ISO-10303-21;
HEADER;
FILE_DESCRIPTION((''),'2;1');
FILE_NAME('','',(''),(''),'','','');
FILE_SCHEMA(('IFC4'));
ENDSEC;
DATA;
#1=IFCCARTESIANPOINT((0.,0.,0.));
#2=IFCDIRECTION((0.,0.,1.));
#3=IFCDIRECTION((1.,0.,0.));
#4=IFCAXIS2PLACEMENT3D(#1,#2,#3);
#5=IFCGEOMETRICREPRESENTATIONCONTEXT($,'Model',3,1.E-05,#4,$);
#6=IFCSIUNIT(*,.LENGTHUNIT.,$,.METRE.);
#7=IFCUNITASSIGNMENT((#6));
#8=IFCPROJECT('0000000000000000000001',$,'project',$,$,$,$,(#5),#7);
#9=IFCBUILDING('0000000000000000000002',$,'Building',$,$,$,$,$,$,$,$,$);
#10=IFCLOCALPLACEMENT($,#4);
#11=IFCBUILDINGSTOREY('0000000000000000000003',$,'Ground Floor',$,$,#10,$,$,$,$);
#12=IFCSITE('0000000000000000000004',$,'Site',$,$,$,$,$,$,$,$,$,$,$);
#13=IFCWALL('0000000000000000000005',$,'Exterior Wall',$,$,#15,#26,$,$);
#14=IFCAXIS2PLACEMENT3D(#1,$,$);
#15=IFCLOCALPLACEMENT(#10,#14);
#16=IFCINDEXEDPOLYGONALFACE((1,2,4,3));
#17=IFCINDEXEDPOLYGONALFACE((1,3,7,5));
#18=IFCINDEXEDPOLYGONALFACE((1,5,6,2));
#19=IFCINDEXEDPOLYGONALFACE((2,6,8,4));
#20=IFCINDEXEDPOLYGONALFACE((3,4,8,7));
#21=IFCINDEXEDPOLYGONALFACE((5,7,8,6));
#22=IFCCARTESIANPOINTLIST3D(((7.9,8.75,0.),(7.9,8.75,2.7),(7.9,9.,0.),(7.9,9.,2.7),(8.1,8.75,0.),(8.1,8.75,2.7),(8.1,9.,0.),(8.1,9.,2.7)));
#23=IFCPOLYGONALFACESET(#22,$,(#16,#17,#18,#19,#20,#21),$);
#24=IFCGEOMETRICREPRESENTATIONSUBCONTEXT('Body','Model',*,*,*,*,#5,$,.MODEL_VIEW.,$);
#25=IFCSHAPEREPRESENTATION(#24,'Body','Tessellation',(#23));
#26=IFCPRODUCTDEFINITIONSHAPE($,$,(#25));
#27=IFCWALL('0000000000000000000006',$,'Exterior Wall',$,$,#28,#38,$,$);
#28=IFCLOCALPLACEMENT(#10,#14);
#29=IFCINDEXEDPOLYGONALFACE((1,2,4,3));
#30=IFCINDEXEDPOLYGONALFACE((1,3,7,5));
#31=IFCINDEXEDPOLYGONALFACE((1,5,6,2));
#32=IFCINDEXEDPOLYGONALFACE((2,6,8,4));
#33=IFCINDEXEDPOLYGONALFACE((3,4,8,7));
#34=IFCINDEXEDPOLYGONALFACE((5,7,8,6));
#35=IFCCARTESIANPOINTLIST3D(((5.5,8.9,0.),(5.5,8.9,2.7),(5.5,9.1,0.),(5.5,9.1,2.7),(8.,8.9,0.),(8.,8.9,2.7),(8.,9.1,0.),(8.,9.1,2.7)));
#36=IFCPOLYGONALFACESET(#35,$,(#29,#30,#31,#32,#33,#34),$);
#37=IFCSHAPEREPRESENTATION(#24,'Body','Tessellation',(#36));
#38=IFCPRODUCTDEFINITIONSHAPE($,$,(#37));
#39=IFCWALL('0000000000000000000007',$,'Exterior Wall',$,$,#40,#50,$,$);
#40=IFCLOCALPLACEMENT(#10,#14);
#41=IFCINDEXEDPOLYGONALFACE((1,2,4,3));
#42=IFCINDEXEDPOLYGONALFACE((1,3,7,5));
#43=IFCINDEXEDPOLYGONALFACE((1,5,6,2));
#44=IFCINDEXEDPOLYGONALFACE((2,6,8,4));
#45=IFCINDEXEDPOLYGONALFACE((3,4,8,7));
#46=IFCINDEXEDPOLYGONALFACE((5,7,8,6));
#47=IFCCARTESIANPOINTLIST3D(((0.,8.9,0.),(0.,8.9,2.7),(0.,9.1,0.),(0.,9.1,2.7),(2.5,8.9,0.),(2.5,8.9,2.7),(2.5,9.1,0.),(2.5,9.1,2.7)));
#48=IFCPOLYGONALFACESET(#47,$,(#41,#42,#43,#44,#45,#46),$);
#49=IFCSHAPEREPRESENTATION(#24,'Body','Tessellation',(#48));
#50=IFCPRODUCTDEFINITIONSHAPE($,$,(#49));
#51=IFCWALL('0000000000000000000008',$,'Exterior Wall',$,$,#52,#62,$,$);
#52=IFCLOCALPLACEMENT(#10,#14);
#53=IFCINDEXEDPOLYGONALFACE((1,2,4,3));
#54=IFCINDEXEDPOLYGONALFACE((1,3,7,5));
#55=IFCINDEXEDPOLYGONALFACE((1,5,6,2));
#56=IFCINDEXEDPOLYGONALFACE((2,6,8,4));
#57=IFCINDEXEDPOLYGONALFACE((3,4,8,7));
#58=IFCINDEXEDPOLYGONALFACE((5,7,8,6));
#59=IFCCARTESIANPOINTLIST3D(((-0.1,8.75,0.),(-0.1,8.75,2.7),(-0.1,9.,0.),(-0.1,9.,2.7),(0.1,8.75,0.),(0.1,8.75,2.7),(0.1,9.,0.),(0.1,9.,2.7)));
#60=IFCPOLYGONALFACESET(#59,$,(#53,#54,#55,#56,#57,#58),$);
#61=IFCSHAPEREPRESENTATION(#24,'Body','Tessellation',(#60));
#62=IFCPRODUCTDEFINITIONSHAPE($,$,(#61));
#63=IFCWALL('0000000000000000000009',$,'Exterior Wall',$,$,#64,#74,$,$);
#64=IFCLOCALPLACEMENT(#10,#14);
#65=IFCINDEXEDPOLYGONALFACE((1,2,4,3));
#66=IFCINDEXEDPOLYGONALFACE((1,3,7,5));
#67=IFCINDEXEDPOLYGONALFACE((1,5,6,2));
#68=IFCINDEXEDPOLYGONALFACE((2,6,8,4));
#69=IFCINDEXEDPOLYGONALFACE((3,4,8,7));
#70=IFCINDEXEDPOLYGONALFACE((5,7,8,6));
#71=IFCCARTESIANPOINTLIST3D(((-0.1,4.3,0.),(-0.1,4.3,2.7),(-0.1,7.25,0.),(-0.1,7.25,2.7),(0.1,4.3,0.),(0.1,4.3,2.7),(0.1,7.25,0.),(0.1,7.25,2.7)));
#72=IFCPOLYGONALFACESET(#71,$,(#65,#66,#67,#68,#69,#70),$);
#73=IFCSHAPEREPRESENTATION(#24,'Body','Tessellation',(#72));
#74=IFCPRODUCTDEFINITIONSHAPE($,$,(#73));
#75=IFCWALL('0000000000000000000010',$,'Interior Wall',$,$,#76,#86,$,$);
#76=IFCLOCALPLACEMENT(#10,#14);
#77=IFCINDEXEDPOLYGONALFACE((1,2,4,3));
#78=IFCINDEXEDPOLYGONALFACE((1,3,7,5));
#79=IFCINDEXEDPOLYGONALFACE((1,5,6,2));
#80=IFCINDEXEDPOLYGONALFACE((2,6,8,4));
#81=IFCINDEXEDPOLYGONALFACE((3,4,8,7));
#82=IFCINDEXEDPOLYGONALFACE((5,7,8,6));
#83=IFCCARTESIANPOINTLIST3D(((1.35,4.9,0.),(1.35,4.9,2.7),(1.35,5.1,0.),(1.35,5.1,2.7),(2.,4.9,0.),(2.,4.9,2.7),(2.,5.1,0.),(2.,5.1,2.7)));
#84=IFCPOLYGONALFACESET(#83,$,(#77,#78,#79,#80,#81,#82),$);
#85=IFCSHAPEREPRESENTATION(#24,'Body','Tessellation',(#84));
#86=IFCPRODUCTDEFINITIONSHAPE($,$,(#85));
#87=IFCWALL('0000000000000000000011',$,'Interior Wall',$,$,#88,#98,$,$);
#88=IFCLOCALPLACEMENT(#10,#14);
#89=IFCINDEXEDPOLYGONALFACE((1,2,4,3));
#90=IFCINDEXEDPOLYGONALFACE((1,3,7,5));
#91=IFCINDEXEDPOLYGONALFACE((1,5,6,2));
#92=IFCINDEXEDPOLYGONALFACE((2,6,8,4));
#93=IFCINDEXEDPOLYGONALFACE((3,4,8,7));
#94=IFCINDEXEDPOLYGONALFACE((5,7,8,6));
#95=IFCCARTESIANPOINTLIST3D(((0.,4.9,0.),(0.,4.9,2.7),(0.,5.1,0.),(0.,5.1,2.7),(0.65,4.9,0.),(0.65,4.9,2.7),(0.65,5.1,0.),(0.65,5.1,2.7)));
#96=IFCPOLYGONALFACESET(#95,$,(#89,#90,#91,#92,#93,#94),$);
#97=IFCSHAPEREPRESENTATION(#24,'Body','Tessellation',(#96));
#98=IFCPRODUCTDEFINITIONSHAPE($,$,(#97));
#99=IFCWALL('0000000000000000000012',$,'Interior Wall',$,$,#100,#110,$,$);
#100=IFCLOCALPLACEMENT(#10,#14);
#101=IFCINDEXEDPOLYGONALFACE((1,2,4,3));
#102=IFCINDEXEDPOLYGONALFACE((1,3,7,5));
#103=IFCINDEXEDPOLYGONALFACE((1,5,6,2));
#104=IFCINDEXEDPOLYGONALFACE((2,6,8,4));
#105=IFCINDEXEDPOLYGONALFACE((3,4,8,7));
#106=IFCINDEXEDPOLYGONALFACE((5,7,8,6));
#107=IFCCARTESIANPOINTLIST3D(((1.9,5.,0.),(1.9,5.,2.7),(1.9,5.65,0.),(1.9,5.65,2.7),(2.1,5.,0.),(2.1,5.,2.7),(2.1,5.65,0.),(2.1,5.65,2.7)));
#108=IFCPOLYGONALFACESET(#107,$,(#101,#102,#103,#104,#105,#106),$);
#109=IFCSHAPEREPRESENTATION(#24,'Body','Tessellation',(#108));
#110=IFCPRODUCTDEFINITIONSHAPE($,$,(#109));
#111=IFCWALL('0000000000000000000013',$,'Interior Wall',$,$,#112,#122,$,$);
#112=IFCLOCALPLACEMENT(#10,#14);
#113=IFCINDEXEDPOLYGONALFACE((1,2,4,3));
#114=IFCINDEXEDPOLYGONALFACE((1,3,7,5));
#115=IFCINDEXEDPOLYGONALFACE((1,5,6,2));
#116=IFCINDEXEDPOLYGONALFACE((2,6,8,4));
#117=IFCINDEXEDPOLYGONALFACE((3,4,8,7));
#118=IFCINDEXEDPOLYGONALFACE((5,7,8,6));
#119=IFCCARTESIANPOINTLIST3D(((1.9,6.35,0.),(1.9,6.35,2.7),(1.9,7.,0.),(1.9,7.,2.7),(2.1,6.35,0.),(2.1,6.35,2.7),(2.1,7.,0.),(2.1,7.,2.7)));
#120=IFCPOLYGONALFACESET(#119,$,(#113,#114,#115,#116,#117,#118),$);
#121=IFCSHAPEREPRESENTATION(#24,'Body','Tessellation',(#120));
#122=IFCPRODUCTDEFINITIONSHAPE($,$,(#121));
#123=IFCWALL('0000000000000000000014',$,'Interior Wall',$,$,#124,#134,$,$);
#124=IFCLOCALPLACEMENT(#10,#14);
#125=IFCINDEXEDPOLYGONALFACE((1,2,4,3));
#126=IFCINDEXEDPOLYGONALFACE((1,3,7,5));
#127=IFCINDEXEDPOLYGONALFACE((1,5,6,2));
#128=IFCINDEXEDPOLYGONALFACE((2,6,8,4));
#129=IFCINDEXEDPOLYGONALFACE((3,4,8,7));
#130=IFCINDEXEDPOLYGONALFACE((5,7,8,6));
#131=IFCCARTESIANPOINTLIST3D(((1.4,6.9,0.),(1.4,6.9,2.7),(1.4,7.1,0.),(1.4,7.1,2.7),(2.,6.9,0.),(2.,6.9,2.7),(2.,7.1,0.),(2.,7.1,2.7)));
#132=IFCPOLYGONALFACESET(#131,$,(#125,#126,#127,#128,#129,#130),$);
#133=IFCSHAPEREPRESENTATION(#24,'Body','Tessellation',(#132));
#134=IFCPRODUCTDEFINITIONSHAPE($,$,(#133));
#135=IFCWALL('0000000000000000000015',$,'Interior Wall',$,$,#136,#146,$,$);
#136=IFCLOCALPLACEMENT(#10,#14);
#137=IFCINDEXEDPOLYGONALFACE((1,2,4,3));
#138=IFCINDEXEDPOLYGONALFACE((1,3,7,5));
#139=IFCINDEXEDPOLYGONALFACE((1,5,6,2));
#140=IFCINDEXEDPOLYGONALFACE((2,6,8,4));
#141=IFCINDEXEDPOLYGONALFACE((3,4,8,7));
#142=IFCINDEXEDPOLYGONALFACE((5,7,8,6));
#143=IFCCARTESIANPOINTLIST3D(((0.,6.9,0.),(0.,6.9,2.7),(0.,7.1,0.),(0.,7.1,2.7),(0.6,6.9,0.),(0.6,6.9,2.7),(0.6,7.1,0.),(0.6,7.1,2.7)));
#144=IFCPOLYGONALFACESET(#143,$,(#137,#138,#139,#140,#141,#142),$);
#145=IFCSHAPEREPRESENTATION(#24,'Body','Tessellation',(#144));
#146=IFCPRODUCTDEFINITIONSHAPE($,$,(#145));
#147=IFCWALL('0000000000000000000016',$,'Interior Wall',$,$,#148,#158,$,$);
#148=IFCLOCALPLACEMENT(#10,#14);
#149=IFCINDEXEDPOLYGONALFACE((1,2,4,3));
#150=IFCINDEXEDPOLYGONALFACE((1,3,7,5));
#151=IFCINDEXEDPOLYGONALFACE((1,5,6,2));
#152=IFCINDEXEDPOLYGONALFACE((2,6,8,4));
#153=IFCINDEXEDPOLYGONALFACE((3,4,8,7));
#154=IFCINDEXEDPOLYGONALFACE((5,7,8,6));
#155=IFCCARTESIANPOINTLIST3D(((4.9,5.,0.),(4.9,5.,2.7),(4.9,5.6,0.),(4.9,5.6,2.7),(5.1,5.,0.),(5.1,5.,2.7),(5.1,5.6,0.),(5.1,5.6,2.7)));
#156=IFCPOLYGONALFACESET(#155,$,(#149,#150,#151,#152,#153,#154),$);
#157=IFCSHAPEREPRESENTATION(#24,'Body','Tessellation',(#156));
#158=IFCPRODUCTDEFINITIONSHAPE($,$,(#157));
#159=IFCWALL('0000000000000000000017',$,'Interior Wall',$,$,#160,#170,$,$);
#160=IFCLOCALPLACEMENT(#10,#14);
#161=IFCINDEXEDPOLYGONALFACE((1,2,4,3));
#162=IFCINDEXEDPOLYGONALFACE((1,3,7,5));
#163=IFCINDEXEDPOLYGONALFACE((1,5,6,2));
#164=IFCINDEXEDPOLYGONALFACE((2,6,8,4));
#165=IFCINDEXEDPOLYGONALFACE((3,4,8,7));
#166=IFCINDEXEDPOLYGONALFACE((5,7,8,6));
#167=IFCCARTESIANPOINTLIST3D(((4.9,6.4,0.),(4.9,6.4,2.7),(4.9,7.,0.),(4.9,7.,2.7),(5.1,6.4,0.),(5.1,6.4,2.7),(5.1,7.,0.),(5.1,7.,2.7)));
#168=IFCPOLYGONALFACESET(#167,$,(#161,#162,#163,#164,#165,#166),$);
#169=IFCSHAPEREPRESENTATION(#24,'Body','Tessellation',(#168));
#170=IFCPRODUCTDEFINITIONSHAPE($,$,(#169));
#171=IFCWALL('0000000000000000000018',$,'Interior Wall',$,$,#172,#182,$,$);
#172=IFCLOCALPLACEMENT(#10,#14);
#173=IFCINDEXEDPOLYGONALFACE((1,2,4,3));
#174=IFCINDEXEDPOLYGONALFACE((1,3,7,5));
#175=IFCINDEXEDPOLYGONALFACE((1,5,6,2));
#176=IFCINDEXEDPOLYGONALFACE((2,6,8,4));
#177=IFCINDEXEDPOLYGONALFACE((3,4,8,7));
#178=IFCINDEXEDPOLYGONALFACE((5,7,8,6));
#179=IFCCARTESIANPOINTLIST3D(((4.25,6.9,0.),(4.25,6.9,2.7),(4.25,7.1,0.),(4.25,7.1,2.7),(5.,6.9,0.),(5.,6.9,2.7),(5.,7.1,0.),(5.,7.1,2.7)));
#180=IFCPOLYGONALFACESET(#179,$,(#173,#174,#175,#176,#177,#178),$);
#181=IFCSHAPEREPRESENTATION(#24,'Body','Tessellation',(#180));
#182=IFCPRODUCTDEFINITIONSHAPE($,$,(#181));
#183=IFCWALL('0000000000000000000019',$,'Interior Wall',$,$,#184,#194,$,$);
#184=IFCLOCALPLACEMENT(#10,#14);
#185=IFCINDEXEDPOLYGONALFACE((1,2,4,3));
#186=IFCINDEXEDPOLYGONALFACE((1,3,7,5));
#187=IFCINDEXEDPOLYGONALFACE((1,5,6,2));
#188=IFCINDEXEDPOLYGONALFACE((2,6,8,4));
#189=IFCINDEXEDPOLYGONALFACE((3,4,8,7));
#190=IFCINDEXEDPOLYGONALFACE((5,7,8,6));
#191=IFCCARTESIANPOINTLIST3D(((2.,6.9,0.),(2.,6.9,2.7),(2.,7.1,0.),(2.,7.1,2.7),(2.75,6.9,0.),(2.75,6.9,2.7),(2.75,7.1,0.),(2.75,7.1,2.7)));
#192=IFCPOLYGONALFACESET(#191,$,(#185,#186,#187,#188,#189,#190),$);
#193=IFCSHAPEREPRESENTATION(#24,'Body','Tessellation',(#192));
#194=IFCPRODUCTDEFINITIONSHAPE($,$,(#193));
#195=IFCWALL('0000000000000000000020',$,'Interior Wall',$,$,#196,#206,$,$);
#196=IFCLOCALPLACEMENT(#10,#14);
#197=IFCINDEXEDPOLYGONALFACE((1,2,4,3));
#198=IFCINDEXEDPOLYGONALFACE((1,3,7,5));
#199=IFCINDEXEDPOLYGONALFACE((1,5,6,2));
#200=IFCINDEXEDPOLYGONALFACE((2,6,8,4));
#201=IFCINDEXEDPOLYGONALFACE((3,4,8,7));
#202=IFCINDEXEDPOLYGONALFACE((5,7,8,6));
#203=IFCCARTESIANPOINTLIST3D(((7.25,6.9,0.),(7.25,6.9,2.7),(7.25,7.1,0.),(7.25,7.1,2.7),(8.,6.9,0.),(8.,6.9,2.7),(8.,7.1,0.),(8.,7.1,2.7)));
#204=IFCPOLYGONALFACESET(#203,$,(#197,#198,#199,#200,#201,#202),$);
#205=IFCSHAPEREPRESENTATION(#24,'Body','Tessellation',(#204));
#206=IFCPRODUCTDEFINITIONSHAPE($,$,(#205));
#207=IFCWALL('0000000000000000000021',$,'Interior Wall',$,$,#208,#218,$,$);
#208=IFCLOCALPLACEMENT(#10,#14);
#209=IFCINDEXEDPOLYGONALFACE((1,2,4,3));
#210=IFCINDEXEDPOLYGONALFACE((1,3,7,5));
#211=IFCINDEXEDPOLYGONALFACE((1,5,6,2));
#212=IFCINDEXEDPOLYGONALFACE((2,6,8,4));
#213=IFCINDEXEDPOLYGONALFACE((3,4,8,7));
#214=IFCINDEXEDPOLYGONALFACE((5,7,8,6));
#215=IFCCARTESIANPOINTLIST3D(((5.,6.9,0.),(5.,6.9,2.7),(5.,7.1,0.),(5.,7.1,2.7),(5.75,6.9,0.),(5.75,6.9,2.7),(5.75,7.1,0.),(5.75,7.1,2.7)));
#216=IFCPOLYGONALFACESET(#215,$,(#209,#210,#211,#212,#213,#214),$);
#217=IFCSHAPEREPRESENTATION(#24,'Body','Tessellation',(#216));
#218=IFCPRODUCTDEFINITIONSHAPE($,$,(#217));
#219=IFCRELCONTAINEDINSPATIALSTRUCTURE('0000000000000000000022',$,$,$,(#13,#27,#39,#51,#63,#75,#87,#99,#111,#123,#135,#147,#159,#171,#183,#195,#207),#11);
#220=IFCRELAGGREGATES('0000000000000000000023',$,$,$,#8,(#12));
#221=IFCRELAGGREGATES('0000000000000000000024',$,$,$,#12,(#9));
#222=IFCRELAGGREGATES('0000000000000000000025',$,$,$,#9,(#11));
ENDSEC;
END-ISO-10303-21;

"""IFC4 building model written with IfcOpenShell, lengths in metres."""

from ifc_helpers import new_model, si_unit, frame, origin_with_axes, place, context, subcontext, project, spatial, indexed_curve, outline, extrude, element, save


model = new_model("IFC4")

# Units and contexts
model_context = context("Model", 3, precision=1e-05, world=origin_with_axes())
body_context = subcontext(model_context, "Body", "Model", "MODEL_VIEW")
ifc_project = project(units=[si_unit("LENGTHUNIT", "METRE")], contexts=[model_context])

# Site, building, storey
site = spatial("IfcSite", under=ifc_project, Name="Site")
building = spatial("IfcBuilding", under=site, Name="Building")
storey_placement = place(None, origin_with_axes())
storey = spatial("IfcBuildingStorey", under=building, at=storey_placement, Name="Ground Floor")

# Walls
wall_1_placement = place(storey_placement, frame((8.0, 8.75, 0.0), z_axis=(0.0, 0.0, 1.0), x_axis=(0.0, 1.0, 0.0)))
element("IfcWall", 1, at=wall_1_placement, inside=storey, Name="Exterior Wall", context=body_context, shape_type="SweptSolid", body=[
    extrude(outline(indexed_curve([(0.0, 0.0), (0.0, 0.2), (0.25, 0.2), (0.25, 0.0), (0.0, 0.0)], self_intersect=False)), frame((0.0, -0.1, 0.0), z_axis=(0.0, 0.0, 1.0), x_axis=(1.0, 0.0, 0.0)), (0.0, 0.0, 1.0), 2.7),
])
for number, where, z_axis, x_axis, name in (
    (2, (8.0, 9.0, 0.0), (0.0, 0.0, 1.0), (-1.0, 0.0, 0.0), "Exterior Wall"),
    (3, (2.5, 9.0, 0.0), (0.0, 0.0, 1.0), (-1.0, 0.0, 0.0), "Exterior Wall"),
):
    element("IfcWall", number, at=place(storey_placement, frame(where, z_axis=z_axis, x_axis=x_axis)), inside=storey, Name=name, context=body_context, shape_type="SweptSolid", body=[
        extrude(outline(indexed_curve([(0.0, 0.0), (0.0, 0.2), (2.5, 0.2), (2.5, 0.0), (0.0, 0.0)], self_intersect=False)), frame((0.0, -0.1, 0.0), z_axis=(0.0, 0.0, 1.0), x_axis=(1.0, 0.0, 0.0)), (0.0, 0.0, 1.0), 2.7),
    ])
wall_2_placement = place(storey_placement, frame((0.0, 9.0, 0.0), z_axis=(0.0, 0.0, 1.0), x_axis=(0.0, -1.0, 0.0)))
element("IfcWall", 4, at=wall_2_placement, inside=storey, Name="Exterior Wall", context=body_context, shape_type="SweptSolid", body=[
    extrude(outline(indexed_curve([(0.0, 0.0), (0.0, 0.2), (0.25, 0.2), (0.25, 0.0), (0.0, 0.0)], self_intersect=False)), frame((0.0, -0.1, 0.0), z_axis=(0.0, 0.0, 1.0), x_axis=(1.0, 0.0, 0.0)), (0.0, 0.0, 1.0), 2.7),
])
wall_3_placement = place(storey_placement, frame((0.0, 7.25, 0.0), z_axis=(0.0, 0.0, 1.0), x_axis=(0.0, -1.0, 0.0)))
element("IfcWall", 5, at=wall_3_placement, inside=storey, Name="Exterior Wall", context=body_context, shape_type="SweptSolid", body=[
    extrude(outline(indexed_curve([(0.0, 0.0), (0.0, 0.2), (2.95, 0.2), (2.95, 0.0), (0.0, 0.0)], self_intersect=False)), frame((0.0, -0.1, 0.0), z_axis=(0.0, 0.0, 1.0), x_axis=(1.0, 0.0, 0.0)), (0.0, 0.0, 1.0), 2.7),
])
for number, where, z_axis, x_axis, name in (
    (6, (2.0, 5.0, 0.0), (0.0, 0.0, 1.0), (-1.0, 0.0, 0.0), "Interior Wall"),
    (7, (0.65, 5.0, 0.0), (0.0, 0.0, 1.0), (-1.0, 0.0, 0.0), "Interior Wall"),
):
    element("IfcWall", number, at=place(storey_placement, frame(where, z_axis=z_axis, x_axis=x_axis)), inside=storey, Name=name, context=body_context, shape_type="SweptSolid", body=[
        extrude(outline(indexed_curve([(0.0, 0.0), (0.0, 0.2), (0.65, 0.2), (0.65, 0.0), (0.0, 0.0)], self_intersect=False)), frame((0.0, -0.1, 0.0), z_axis=(0.0, 0.0, 1.0), x_axis=(1.0, 0.0, 0.0)), (0.0, 0.0, 1.0), 2.7),
    ])
for number, where, z_axis, x_axis, name in (
    (8, (2.0, 5.0, 0.0), (0.0, 0.0, 1.0), (0.0, 1.0, 0.0), "Interior Wall"),
    (9, (2.0, 6.35, 0.0), (0.0, 0.0, 1.0), (0.0, 1.0, 0.0), "Interior Wall"),
):
    element("IfcWall", number, at=place(storey_placement, frame(where, z_axis=z_axis, x_axis=x_axis)), inside=storey, Name=name, context=body_context, shape_type="SweptSolid", body=[
        extrude(outline(indexed_curve([(0.0, 0.0), (0.0, 0.2), (0.65, 0.2), (0.65, 0.0), (0.0, 0.0)], self_intersect=False)), frame((0.0, -0.1, 0.0), z_axis=(0.0, 0.0, 1.0), x_axis=(1.0, 0.0, 0.0)), (0.0, 0.0, 1.0), 2.7),
    ])
for number, where, z_axis, x_axis, name in (
    (10, (2.0, 7.0, 0.0), (0.0, 0.0, 1.0), (-1.0, 0.0, 0.0), "Interior Wall"),
    (11, (0.6, 7.0, 0.0), (0.0, 0.0, 1.0), (-1.0, 0.0, 0.0), "Interior Wall"),
):
    element("IfcWall", number, at=place(storey_placement, frame(where, z_axis=z_axis, x_axis=x_axis)), inside=storey, Name=name, context=body_context, shape_type="SweptSolid", body=[
        extrude(outline(indexed_curve([(0.0, 0.0), (0.0, 0.2), (0.6, 0.2), (0.6, 0.0), (0.0, 0.0)], self_intersect=False)), frame((0.0, -0.1, 0.0), z_axis=(0.0, 0.0, 1.0), x_axis=(1.0, 0.0, 0.0)), (0.0, 0.0, 1.0), 2.7),
    ])
for number, where, z_axis, x_axis, name in (
    (12, (5.0, 5.0, 0.0), (0.0, 0.0, 1.0), (0.0, 1.0, 0.0), "Interior Wall"),
    (13, (5.0, 6.4, 0.0), (0.0, 0.0, 1.0), (0.0, 1.0, 0.0), "Interior Wall"),
):
    element("IfcWall", number, at=place(storey_placement, frame(where, z_axis=z_axis, x_axis=x_axis)), inside=storey, Name=name, context=body_context, shape_type="SweptSolid", body=[
        extrude(outline(indexed_curve([(0.0, 0.0), (0.0, 0.2), (0.6, 0.2), (0.6, 0.0), (0.0, 0.0)], self_intersect=False)), frame((0.0, -0.1, 0.0), z_axis=(0.0, 0.0, 1.0), x_axis=(1.0, 0.0, 0.0)), (0.0, 0.0, 1.0), 2.7),
    ])
for number, where, z_axis, x_axis, name in (
    (14, (5.0, 7.0, 0.0), (0.0, 0.0, 1.0), (-1.0, 0.0, 0.0), "Interior Wall"),
    (15, (2.75, 7.0, 0.0), (0.0, 0.0, 1.0), (-1.0, 0.0, 0.0), "Interior Wall"),
    (16, (8.0, 7.0, 0.0), (0.0, 0.0, 1.0), (-1.0, 0.0, 0.0), "Interior Wall"),
    (17, (5.75, 7.0, 0.0), (0.0, 0.0, 1.0), (-1.0, 0.0, 0.0), "Interior Wall"),
):
    element("IfcWall", number, at=place(storey_placement, frame(where, z_axis=z_axis, x_axis=x_axis)), inside=storey, Name=name, context=body_context, shape_type="SweptSolid", body=[
        extrude(outline(indexed_curve([(0.0, 0.0), (0.0, 0.2), (0.75, 0.2), (0.75, 0.0), (0.0, 0.0)], self_intersect=False)), frame((0.0, -0.1, 0.0), z_axis=(0.0, 0.0, 1.0), x_axis=(1.0, 0.0, 0.0)), (0.0, 0.0, 1.0), 2.7),
    ])

save(model, "model.ifc")
